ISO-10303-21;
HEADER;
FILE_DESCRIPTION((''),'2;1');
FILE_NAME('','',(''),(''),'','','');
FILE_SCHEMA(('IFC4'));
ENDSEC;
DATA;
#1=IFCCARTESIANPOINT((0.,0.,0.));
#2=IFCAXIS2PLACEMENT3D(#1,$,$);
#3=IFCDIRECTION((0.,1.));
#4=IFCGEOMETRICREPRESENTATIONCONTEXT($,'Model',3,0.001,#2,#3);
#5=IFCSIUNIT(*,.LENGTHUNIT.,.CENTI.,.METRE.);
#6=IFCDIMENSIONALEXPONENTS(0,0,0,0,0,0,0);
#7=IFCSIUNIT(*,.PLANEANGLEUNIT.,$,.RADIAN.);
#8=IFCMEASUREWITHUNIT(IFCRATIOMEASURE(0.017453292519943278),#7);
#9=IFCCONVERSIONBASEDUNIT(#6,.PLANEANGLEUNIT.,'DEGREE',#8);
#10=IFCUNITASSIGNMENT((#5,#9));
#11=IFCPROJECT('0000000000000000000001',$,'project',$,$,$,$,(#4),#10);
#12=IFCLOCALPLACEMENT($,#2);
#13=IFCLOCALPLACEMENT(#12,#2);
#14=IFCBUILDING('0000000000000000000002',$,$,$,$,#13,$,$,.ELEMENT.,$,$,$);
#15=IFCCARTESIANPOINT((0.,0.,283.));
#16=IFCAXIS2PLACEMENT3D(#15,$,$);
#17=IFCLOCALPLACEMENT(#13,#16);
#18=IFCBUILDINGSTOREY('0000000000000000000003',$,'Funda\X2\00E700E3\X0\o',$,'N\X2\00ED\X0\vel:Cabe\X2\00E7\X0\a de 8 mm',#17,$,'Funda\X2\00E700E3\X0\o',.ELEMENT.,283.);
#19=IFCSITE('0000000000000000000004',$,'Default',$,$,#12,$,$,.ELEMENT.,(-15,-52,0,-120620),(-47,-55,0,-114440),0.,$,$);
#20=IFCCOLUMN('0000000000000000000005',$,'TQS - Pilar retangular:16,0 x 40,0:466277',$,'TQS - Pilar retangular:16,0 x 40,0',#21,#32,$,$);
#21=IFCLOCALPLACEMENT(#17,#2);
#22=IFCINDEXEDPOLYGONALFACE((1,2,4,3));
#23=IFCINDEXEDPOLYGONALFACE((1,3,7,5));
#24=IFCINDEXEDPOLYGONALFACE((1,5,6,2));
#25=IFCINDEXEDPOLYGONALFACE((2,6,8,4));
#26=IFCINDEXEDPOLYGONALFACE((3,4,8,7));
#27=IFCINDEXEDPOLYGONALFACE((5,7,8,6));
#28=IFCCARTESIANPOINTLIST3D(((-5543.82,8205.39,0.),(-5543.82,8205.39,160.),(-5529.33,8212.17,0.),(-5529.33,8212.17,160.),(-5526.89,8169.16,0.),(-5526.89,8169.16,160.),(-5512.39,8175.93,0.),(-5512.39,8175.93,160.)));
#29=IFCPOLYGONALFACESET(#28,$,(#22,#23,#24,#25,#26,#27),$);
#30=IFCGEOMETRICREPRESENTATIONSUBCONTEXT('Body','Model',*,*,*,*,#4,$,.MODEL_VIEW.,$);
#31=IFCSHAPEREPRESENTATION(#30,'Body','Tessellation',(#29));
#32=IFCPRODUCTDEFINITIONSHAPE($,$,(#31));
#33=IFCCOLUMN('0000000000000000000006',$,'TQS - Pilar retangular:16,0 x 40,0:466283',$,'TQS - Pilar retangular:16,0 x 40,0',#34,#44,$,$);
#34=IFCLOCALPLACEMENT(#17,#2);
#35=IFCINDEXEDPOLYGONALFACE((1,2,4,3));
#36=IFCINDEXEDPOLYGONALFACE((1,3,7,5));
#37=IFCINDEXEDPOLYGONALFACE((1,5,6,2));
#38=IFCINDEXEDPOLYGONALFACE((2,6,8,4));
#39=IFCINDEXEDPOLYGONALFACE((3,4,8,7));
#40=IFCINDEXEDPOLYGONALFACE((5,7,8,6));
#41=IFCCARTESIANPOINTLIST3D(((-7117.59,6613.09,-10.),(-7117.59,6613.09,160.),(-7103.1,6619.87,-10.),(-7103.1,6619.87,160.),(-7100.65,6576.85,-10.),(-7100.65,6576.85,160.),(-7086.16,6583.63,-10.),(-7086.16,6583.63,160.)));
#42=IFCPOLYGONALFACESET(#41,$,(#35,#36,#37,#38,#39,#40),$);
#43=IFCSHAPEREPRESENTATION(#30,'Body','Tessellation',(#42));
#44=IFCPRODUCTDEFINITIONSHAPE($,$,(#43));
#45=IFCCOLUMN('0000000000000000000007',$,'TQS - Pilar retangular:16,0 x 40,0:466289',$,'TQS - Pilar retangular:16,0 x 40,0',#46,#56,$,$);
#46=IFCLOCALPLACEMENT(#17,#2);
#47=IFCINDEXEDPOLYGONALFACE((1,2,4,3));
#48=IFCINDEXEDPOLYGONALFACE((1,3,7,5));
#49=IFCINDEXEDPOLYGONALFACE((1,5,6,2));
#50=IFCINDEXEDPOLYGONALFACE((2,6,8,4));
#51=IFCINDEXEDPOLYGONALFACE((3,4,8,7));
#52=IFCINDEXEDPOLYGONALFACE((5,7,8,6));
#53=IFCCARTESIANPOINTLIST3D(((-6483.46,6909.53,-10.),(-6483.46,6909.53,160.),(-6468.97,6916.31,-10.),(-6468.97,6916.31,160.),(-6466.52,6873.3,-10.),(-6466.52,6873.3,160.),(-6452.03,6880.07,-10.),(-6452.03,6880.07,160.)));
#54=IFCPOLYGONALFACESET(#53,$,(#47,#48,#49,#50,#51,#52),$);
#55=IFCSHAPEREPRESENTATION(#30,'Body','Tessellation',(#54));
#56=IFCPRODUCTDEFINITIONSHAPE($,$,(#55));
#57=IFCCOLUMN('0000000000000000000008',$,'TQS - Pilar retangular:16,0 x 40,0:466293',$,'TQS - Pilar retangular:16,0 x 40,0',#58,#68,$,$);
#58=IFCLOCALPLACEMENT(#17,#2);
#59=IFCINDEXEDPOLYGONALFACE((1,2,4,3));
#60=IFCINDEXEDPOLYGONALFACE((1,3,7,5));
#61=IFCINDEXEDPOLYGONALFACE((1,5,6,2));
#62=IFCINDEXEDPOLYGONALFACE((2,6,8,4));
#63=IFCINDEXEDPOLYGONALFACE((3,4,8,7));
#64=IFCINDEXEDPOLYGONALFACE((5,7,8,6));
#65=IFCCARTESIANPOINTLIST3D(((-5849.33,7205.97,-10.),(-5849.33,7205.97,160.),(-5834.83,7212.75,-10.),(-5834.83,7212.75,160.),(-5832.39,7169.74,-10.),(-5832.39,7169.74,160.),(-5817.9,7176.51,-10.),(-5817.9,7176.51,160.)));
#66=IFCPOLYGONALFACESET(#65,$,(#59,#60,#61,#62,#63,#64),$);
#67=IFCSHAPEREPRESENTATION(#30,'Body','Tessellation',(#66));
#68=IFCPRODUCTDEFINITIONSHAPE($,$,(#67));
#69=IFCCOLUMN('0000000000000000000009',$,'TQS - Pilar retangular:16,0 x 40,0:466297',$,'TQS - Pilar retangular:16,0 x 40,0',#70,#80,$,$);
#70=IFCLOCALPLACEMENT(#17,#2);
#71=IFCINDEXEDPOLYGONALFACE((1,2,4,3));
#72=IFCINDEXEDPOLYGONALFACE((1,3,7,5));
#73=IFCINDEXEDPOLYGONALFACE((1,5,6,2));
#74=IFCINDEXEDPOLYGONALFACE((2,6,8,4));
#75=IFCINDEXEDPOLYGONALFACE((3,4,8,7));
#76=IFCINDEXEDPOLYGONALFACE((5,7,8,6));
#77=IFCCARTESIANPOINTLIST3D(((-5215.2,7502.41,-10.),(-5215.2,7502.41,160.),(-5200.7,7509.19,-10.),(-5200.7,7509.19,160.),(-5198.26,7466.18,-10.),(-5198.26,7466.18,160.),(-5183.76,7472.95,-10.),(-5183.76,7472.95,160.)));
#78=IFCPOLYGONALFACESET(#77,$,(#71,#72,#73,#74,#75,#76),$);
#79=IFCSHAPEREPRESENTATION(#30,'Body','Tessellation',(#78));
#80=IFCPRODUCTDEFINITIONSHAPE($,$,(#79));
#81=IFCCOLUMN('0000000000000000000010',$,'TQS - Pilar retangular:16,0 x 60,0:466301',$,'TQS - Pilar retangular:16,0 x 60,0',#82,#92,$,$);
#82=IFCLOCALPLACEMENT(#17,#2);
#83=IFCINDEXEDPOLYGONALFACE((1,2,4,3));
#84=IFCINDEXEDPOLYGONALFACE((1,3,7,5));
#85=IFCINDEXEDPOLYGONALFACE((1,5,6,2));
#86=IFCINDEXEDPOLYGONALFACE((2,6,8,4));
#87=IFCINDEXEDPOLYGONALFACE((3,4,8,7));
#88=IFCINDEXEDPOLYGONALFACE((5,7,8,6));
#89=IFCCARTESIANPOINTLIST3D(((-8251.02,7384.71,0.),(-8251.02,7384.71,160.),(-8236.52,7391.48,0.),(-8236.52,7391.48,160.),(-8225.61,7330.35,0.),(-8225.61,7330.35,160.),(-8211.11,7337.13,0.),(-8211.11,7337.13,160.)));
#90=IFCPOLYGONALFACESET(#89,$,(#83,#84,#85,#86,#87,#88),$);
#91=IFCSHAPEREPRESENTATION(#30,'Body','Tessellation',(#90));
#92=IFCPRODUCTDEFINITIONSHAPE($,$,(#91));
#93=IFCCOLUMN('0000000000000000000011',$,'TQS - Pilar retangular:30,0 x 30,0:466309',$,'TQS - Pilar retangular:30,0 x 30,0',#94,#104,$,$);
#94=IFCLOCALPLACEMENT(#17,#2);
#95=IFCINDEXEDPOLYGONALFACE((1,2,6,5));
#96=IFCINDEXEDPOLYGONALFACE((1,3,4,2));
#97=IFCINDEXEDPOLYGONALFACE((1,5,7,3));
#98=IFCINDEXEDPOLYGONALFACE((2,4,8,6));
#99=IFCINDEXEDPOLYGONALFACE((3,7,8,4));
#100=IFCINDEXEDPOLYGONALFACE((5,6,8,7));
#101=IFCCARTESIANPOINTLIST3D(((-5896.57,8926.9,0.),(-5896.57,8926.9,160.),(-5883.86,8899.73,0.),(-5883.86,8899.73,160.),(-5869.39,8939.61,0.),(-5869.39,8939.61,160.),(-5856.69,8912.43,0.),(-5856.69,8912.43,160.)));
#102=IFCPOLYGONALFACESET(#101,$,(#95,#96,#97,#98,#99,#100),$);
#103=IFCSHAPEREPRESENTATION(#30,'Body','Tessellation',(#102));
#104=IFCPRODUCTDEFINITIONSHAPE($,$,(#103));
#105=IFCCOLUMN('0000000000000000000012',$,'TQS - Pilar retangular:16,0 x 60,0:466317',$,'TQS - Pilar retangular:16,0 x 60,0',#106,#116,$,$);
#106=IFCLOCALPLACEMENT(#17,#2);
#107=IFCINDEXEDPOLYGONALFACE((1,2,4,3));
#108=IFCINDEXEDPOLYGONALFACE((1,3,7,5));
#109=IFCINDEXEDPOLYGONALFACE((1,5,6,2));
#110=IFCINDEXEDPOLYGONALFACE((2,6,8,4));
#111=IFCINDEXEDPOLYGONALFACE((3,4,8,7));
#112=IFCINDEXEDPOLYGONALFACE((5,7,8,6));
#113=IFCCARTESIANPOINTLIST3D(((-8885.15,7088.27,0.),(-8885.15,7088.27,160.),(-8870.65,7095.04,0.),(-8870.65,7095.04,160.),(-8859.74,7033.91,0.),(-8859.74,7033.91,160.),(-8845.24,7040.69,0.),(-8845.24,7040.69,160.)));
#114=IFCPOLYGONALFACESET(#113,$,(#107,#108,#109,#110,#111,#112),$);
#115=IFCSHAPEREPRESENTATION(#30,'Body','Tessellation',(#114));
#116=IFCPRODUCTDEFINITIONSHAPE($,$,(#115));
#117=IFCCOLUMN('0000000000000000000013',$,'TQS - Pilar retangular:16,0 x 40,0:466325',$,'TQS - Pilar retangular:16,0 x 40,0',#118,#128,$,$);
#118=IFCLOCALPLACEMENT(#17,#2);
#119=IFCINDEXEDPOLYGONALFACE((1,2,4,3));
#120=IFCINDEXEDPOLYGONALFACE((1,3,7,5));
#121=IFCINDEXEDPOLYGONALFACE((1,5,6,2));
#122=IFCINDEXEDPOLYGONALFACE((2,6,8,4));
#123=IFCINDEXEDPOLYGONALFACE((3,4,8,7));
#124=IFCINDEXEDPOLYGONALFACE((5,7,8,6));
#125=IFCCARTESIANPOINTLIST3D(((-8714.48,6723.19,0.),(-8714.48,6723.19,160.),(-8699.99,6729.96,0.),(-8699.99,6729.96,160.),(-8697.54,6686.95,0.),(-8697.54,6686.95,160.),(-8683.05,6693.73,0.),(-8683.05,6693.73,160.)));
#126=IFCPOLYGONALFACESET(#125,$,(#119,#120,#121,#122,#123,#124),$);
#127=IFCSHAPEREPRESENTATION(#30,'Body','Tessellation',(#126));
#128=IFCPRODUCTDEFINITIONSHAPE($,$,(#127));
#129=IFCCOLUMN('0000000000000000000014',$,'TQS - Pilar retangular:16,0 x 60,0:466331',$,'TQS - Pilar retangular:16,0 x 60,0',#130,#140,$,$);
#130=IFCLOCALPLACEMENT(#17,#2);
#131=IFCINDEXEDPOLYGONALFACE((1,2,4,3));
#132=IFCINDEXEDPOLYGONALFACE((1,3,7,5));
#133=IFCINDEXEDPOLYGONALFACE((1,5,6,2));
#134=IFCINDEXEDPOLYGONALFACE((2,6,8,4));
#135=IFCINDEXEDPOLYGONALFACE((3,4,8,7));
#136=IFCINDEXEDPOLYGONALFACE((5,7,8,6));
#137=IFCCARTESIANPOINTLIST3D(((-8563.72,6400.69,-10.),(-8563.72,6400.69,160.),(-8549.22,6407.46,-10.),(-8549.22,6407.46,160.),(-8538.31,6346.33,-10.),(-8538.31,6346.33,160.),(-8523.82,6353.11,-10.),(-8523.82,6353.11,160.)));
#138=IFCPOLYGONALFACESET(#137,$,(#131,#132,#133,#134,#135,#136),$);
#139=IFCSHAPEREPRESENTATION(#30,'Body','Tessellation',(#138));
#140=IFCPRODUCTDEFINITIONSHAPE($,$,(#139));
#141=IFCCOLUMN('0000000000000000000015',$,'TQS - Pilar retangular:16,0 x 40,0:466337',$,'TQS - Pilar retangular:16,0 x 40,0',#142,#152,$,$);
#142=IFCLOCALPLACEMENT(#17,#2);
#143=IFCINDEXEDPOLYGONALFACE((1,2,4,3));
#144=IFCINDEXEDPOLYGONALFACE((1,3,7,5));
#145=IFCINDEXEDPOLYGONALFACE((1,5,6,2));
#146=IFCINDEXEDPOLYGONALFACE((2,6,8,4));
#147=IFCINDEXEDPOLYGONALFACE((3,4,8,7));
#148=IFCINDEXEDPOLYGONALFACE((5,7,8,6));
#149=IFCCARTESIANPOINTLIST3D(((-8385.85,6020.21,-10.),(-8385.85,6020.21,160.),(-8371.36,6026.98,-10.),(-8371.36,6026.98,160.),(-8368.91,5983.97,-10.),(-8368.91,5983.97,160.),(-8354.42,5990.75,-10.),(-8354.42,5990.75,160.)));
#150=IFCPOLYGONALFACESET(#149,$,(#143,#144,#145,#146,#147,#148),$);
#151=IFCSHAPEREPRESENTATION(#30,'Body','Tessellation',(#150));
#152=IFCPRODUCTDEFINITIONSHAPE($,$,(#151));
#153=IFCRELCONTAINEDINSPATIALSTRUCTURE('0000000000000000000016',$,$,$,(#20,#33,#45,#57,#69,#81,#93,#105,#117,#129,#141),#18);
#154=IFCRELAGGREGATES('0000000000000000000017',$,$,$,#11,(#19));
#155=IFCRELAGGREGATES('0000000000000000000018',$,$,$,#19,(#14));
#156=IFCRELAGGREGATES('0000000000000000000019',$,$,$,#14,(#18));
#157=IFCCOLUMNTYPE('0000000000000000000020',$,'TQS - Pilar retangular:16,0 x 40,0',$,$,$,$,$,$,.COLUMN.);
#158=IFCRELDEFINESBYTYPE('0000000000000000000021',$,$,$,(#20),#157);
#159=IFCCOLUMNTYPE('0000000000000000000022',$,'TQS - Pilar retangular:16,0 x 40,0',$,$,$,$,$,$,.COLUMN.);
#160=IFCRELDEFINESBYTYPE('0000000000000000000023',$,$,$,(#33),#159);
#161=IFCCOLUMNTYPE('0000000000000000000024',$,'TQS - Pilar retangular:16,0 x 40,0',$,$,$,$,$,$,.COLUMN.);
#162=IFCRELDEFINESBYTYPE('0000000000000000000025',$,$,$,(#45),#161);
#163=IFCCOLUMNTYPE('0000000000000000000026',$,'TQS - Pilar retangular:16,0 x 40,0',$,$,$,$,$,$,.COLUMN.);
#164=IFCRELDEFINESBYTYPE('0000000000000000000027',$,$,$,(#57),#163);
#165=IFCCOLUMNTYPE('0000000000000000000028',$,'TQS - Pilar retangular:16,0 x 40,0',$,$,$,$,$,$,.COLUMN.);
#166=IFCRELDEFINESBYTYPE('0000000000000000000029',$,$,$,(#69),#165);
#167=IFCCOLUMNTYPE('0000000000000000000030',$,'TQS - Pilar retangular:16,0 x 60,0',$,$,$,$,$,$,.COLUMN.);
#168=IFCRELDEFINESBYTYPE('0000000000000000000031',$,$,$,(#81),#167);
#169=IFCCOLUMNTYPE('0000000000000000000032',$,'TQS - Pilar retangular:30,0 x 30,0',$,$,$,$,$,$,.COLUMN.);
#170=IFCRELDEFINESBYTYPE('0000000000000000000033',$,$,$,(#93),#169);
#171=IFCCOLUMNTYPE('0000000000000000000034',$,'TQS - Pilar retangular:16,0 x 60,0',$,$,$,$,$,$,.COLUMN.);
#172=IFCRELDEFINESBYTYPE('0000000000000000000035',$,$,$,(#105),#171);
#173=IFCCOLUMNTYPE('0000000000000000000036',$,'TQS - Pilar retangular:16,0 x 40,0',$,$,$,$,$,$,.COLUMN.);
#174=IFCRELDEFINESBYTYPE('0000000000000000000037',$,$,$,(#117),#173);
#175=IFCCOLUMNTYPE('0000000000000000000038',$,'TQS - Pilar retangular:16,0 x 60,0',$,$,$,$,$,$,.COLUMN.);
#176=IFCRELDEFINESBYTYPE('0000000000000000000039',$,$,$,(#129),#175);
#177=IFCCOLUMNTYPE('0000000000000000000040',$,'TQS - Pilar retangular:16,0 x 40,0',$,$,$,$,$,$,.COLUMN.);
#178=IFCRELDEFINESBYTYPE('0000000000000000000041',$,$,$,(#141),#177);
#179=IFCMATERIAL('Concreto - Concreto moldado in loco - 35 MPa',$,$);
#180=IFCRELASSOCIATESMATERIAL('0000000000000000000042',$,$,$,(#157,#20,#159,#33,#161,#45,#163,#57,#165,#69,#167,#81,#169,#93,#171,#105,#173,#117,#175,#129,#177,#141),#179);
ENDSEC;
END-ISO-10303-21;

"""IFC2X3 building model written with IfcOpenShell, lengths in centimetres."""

from ifc_helpers import new_model, entity, si_unit, converted_unit, direction, frame, frame_2d, origin, origin_2d_with_axis, place, context, subcontext, project, spatial, rectangle, extrude, source, transform, mapped, material, type_object, type_shapes, element, save


model = new_model("IFC2X3")

# Units and contexts
model_context = context("Model", 3, precision=0.001, world=origin(), true_north=direction((0.0, 1.0)))
body_context = subcontext(model_context, "Body", "Model", "MODEL_VIEW")
ifc_project = project(units=[si_unit("LENGTHUNIT", "METRE", prefix="CENTI"), converted_unit("PLANEANGLEUNIT", "DEGREE", entity("IfcRatioMeasure", 0.017453292519943278), si_unit("PLANEANGLEUNIT", "RADIAN"), dimensions=[0, 0, 0, 0, 0, 0, 0])], contexts=[model_context])

# Site, building, storey
site_placement = place(None, origin())
site = spatial("IfcSite", under=ifc_project, at=site_placement, Name="Default", CompositionType="ELEMENT", RefLatitude=(-15, -52, 0, -120620), RefLongitude=(-47, -55, 0, -114440), RefElevation=0.0)
building_placement = place(site_placement, origin())
building = spatial("IfcBuilding", under=site, at=building_placement, CompositionType="ELEMENT")
storey_placement = place(building_placement, frame((0.0, 0.0, 283.0)))
storey = spatial("IfcBuildingStorey", under=building, at=storey_placement, Name="Fundação", ObjectType="Nível:Cabeça de 8 mm", LongName="Fundação", CompositionType="ELEMENT", Elevation=283.0)

# Columns
ifc_material_1 = material(Name="Concreto - Concreto moldado in loco - 35 MPa")
column_type_1 = type_object("IfcColumnType", Name="TQS - Pilar retangular:16,0 x 40,0", PredefinedType="COLUMN", material=ifc_material_1)
shared_shape_1 = source(origin(), body_context, "Body", "SweptSolid", [
    extrude(rectangle(XDim=40.0, YDim=16.0, at=origin_2d_with_axis()), frame((-5528.11, 8190.66, 283.0), z_axis=(0.0, 0.0, 1.0), x_axis=(-0.423488, 0.905902, 0.0)), (0.0, 0.0, 1.0), 160.0),
])
type_shapes(column_type_1, [shared_shape_1])
column_1_placement = place(storey_placement, frame((0.0, 0.0, -283.0)))
element("IfcColumn", 1, at=column_1_placement, inside=storey, type_object=column_type_1, material=ifc_material_1, Name="TQS - Pilar retangular:16,0 x 40,0:466277", ObjectType="TQS - Pilar retangular:16,0 x 40,0", context=body_context, shape_type="MappedRepresentation", body=[
    mapped(shared_shape_1, transform((0.0, 0.0, 0.0), scale=1.0)),
])
column_type_2 = type_object("IfcColumnType", Name="TQS - Pilar retangular:16,0 x 40,0", PredefinedType="COLUMN", material=ifc_material_1)
shared_shape_2 = source(origin(), body_context, "Body", "SweptSolid", [
    extrude(rectangle(XDim=40.0, YDim=16.0, at=frame_2d((0.0, 0.0), x_axis=(1.0, 0.0))), frame((-7101.87, 6598.36, 273.0), z_axis=(0.0, 0.0, 1.0), x_axis=(-0.423488, 0.905902, 0.0)), (0.0, 0.0, 1.0), 170.0),
])
type_shapes(column_type_2, [shared_shape_2])
column_2_placement = place(storey_placement, frame((0.0, 0.0, -283.0)))
element("IfcColumn", 2, at=column_2_placement, inside=storey, type_object=column_type_2, material=ifc_material_1, Name="TQS - Pilar retangular:16,0 x 40,0:466283", ObjectType="TQS - Pilar retangular:16,0 x 40,0", context=body_context, shape_type="MappedRepresentation", body=[
    mapped(shared_shape_2, transform((0.0, 0.0, 0.0), scale=1.0)),
])
column_type_3 = type_object("IfcColumnType", Name="TQS - Pilar retangular:16,0 x 40,0", PredefinedType="COLUMN", material=ifc_material_1)
shared_shape_3 = source(origin(), body_context, "Body", "SweptSolid", [
    extrude(rectangle(XDim=40.0, YDim=16.0, at=frame_2d((0.0, 0.0), x_axis=(1.0, 0.0))), frame((-6467.74, 6894.8, 273.0), z_axis=(0.0, 0.0, 1.0), x_axis=(-0.423488, 0.905902, 0.0)), (0.0, 0.0, 1.0), 170.0),
])
type_shapes(column_type_3, [shared_shape_3])
column_3_placement = place(storey_placement, frame((0.0, 0.0, -283.0)))
element("IfcColumn", 3, at=column_3_placement, inside=storey, type_object=column_type_3, material=ifc_material_1, Name="TQS - Pilar retangular:16,0 x 40,0:466289", ObjectType="TQS - Pilar retangular:16,0 x 40,0", context=body_context, shape_type="MappedRepresentation", body=[
    mapped(shared_shape_3, transform((0.0, 0.0, 0.0), scale=1.0)),
])
column_type_4 = type_object("IfcColumnType", Name="TQS - Pilar retangular:16,0 x 40,0", PredefinedType="COLUMN", material=ifc_material_1)
shared_shape_4 = source(origin(), body_context, "Body", "SweptSolid", [
    extrude(rectangle(XDim=40.0, YDim=16.0, at=origin_2d_with_axis()), frame((-5833.61, 7191.24, 273.0), z_axis=(0.0, 0.0, 1.0), x_axis=(-0.423488, 0.905902, 0.0)), (0.0, 0.0, 1.0), 170.0),
])
type_shapes(column_type_4, [shared_shape_4])
column_4_placement = place(storey_placement, frame((0.0, 0.0, -283.0)))
element("IfcColumn", 4, at=column_4_placement, inside=storey, type_object=column_type_4, material=ifc_material_1, Name="TQS - Pilar retangular:16,0 x 40,0:466293", ObjectType="TQS - Pilar retangular:16,0 x 40,0", context=body_context, shape_type="MappedRepresentation", body=[
    mapped(shared_shape_4, transform((0.0, 0.0, 0.0), scale=1.0)),
])
column_type_5 = type_object("IfcColumnType", Name="TQS - Pilar retangular:16,0 x 40,0", PredefinedType="COLUMN", material=ifc_material_1)
shared_shape_5 = source(origin(), body_context, "Body", "SweptSolid", [
    extrude(rectangle(XDim=40.0, YDim=16.0, at=origin_2d_with_axis()), frame((-5199.48, 7487.68, 273.0), z_axis=(0.0, 0.0, 1.0), x_axis=(-0.423488, 0.905902, 0.0)), (0.0, 0.0, 1.0), 170.0),
])
type_shapes(column_type_5, [shared_shape_5])
column_5_placement = place(storey_placement, frame((0.0, 0.0, -283.0)))
element("IfcColumn", 5, at=column_5_placement, inside=storey, type_object=column_type_5, material=ifc_material_1, Name="TQS - Pilar retangular:16,0 x 40,0:466297", ObjectType="TQS - Pilar retangular:16,0 x 40,0", context=body_context, shape_type="MappedRepresentation", body=[
    mapped(shared_shape_5, transform((0.0, 0.0, 0.0), scale=1.0)),
])
column_type_6 = type_object("IfcColumnType", Name="TQS - Pilar retangular:16,0 x 60,0", PredefinedType="COLUMN", material=ifc_material_1)
shared_shape_6 = source(origin(), body_context, "Body", "SweptSolid", [
    extrude(rectangle(XDim=60.0, YDim=16.0, at=origin_2d_with_axis()), frame((-8231.06, 7360.92, 283.0), z_axis=(0.0, 0.0, 1.0), x_axis=(-0.423488, 0.905902, 0.0)), (0.0, 0.0, 1.0), 160.0),
])
type_shapes(column_type_6, [shared_shape_6])
column_6_placement = place(storey_placement, frame((0.0, 0.0, -283.0)))
element("IfcColumn", 6, at=column_6_placement, inside=storey, type_object=column_type_6, material=ifc_material_1, Name="TQS - Pilar retangular:16,0 x 60,0:466301", ObjectType="TQS - Pilar retangular:16,0 x 60,0", context=body_context, shape_type="MappedRepresentation", body=[
    mapped(shared_shape_6, transform((0.0, 0.0, 0.0), scale=1.0)),
])
column_type_7 = type_object("IfcColumnType", Name="TQS - Pilar retangular:30,0 x 30,0", PredefinedType="COLUMN", material=ifc_material_1)
shared_shape_7 = source(origin(), body_context, "Body", "SweptSolid", [
    extrude(rectangle(XDim=30.0, YDim=30.0, at=origin_2d_with_axis()), frame((-5876.63, 8919.67, 283.0), z_axis=(0.0, 0.0, 1.0), x_axis=(-0.423488, 0.905902, 0.0)), (0.0, 0.0, 1.0), 160.0),
])
type_shapes(column_type_7, [shared_shape_7])
column_7_placement = place(storey_placement, frame((0.0, 0.0, -283.0)))
element("IfcColumn", 7, at=column_7_placement, inside=storey, type_object=column_type_7, material=ifc_material_1, Name="TQS - Pilar retangular:30,0 x 30,0:466309", ObjectType="TQS - Pilar retangular:30,0 x 30,0", context=body_context, shape_type="MappedRepresentation", body=[
    mapped(shared_shape_7, transform((0.0, 0.0, 0.0), scale=1.0)),
])
column_type_8 = type_object("IfcColumnType", Name="TQS - Pilar retangular:16,0 x 60,0", PredefinedType="COLUMN", material=ifc_material_1)
shared_shape_8 = source(origin(), body_context, "Body", "SweptSolid", [
    extrude(rectangle(XDim=60.0, YDim=16.0, at=origin_2d_with_axis()), frame((-8865.19, 7064.48, 283.0), z_axis=(0.0, 0.0, 1.0), x_axis=(-0.423488, 0.905902, 0.0)), (0.0, 0.0, 1.0), 160.0),
])
type_shapes(column_type_8, [shared_shape_8])
column_8_placement = place(storey_placement, frame((0.0, 0.0, -283.0)))
element("IfcColumn", 8, at=column_8_placement, inside=storey, type_object=column_type_8, material=ifc_material_1, Name="TQS - Pilar retangular:16,0 x 60,0:466317", ObjectType="TQS - Pilar retangular:16,0 x 60,0", context=body_context, shape_type="MappedRepresentation", body=[
    mapped(shared_shape_8, transform((0.0, 0.0, 0.0), scale=1.0)),
])
column_type_9 = type_object("IfcColumnType", Name="TQS - Pilar retangular:16,0 x 40,0", PredefinedType="COLUMN", material=ifc_material_1)
shared_shape_9 = source(origin(), body_context, "Body", "SweptSolid", [
    extrude(rectangle(XDim=40.0, YDim=16.0, at=origin_2d_with_axis()), frame((-8698.76, 6708.46, 283.0), z_axis=(0.0, 0.0, 1.0), x_axis=(-0.423488, 0.905902, 0.0)), (0.0, 0.0, 1.0), 160.0),
])
type_shapes(column_type_9, [shared_shape_9])
column_9_placement = place(storey_placement, frame((0.0, 0.0, -283.0)))
element("IfcColumn", 9, at=column_9_placement, inside=storey, type_object=column_type_9, material=ifc_material_1, Name="TQS - Pilar retangular:16,0 x 40,0:466325", ObjectType="TQS - Pilar retangular:16,0 x 40,0", context=body_context, shape_type="MappedRepresentation", body=[
    mapped(shared_shape_9, transform((0.0, 0.0, 0.0), scale=1.0)),
])
column_type_10 = type_object("IfcColumnType", Name="TQS - Pilar retangular:16,0 x 60,0", PredefinedType="COLUMN", material=ifc_material_1)
shared_shape_10 = source(origin(), body_context, "Body", "SweptSolid", [
    extrude(rectangle(XDim=60.0, YDim=16.0, at=origin_2d_with_axis()), frame((-8543.77, 6376.9, 273.0), z_axis=(0.0, 0.0, 1.0), x_axis=(-0.423488, 0.905902, 0.0)), (0.0, 0.0, 1.0), 170.0),
])
type_shapes(column_type_10, [shared_shape_10])
column_10_placement = place(storey_placement, frame((0.0, 0.0, -283.0)))
element("IfcColumn", 10, at=column_10_placement, inside=storey, type_object=column_type_10, material=ifc_material_1, Name="TQS - Pilar retangular:16,0 x 60,0:466331", ObjectType="TQS - Pilar retangular:16,0 x 60,0", context=body_context, shape_type="MappedRepresentation", body=[
    mapped(shared_shape_10, transform((0.0, 0.0, 0.0), scale=1.0)),
])
column_type_11 = type_object("IfcColumnType", Name="TQS - Pilar retangular:16,0 x 40,0", PredefinedType="COLUMN", material=ifc_material_1)
shared_shape_11 = source(origin(), body_context, "Body", "SweptSolid", [
    extrude(rectangle(XDim=40.0, YDim=16.0, at=origin_2d_with_axis()), frame((-8370.14, 6005.48, 273.0), z_axis=(0.0, 0.0, 1.0), x_axis=(-0.423488, 0.905902, 0.0)), (0.0, 0.0, 1.0), 170.0),
])
type_shapes(column_type_11, [shared_shape_11])
column_11_placement = place(storey_placement, frame((0.0, 0.0, -283.0)))
element("IfcColumn", 11, at=column_11_placement, inside=storey, type_object=column_type_11, material=ifc_material_1, Name="TQS - Pilar retangular:16,0 x 40,0:466337", ObjectType="TQS - Pilar retangular:16,0 x 40,0", context=body_context, shape_type="MappedRepresentation", body=[
    mapped(shared_shape_11, transform((0.0, 0.0, 0.0), scale=1.0)),
])

save(model, "model.ifc")
